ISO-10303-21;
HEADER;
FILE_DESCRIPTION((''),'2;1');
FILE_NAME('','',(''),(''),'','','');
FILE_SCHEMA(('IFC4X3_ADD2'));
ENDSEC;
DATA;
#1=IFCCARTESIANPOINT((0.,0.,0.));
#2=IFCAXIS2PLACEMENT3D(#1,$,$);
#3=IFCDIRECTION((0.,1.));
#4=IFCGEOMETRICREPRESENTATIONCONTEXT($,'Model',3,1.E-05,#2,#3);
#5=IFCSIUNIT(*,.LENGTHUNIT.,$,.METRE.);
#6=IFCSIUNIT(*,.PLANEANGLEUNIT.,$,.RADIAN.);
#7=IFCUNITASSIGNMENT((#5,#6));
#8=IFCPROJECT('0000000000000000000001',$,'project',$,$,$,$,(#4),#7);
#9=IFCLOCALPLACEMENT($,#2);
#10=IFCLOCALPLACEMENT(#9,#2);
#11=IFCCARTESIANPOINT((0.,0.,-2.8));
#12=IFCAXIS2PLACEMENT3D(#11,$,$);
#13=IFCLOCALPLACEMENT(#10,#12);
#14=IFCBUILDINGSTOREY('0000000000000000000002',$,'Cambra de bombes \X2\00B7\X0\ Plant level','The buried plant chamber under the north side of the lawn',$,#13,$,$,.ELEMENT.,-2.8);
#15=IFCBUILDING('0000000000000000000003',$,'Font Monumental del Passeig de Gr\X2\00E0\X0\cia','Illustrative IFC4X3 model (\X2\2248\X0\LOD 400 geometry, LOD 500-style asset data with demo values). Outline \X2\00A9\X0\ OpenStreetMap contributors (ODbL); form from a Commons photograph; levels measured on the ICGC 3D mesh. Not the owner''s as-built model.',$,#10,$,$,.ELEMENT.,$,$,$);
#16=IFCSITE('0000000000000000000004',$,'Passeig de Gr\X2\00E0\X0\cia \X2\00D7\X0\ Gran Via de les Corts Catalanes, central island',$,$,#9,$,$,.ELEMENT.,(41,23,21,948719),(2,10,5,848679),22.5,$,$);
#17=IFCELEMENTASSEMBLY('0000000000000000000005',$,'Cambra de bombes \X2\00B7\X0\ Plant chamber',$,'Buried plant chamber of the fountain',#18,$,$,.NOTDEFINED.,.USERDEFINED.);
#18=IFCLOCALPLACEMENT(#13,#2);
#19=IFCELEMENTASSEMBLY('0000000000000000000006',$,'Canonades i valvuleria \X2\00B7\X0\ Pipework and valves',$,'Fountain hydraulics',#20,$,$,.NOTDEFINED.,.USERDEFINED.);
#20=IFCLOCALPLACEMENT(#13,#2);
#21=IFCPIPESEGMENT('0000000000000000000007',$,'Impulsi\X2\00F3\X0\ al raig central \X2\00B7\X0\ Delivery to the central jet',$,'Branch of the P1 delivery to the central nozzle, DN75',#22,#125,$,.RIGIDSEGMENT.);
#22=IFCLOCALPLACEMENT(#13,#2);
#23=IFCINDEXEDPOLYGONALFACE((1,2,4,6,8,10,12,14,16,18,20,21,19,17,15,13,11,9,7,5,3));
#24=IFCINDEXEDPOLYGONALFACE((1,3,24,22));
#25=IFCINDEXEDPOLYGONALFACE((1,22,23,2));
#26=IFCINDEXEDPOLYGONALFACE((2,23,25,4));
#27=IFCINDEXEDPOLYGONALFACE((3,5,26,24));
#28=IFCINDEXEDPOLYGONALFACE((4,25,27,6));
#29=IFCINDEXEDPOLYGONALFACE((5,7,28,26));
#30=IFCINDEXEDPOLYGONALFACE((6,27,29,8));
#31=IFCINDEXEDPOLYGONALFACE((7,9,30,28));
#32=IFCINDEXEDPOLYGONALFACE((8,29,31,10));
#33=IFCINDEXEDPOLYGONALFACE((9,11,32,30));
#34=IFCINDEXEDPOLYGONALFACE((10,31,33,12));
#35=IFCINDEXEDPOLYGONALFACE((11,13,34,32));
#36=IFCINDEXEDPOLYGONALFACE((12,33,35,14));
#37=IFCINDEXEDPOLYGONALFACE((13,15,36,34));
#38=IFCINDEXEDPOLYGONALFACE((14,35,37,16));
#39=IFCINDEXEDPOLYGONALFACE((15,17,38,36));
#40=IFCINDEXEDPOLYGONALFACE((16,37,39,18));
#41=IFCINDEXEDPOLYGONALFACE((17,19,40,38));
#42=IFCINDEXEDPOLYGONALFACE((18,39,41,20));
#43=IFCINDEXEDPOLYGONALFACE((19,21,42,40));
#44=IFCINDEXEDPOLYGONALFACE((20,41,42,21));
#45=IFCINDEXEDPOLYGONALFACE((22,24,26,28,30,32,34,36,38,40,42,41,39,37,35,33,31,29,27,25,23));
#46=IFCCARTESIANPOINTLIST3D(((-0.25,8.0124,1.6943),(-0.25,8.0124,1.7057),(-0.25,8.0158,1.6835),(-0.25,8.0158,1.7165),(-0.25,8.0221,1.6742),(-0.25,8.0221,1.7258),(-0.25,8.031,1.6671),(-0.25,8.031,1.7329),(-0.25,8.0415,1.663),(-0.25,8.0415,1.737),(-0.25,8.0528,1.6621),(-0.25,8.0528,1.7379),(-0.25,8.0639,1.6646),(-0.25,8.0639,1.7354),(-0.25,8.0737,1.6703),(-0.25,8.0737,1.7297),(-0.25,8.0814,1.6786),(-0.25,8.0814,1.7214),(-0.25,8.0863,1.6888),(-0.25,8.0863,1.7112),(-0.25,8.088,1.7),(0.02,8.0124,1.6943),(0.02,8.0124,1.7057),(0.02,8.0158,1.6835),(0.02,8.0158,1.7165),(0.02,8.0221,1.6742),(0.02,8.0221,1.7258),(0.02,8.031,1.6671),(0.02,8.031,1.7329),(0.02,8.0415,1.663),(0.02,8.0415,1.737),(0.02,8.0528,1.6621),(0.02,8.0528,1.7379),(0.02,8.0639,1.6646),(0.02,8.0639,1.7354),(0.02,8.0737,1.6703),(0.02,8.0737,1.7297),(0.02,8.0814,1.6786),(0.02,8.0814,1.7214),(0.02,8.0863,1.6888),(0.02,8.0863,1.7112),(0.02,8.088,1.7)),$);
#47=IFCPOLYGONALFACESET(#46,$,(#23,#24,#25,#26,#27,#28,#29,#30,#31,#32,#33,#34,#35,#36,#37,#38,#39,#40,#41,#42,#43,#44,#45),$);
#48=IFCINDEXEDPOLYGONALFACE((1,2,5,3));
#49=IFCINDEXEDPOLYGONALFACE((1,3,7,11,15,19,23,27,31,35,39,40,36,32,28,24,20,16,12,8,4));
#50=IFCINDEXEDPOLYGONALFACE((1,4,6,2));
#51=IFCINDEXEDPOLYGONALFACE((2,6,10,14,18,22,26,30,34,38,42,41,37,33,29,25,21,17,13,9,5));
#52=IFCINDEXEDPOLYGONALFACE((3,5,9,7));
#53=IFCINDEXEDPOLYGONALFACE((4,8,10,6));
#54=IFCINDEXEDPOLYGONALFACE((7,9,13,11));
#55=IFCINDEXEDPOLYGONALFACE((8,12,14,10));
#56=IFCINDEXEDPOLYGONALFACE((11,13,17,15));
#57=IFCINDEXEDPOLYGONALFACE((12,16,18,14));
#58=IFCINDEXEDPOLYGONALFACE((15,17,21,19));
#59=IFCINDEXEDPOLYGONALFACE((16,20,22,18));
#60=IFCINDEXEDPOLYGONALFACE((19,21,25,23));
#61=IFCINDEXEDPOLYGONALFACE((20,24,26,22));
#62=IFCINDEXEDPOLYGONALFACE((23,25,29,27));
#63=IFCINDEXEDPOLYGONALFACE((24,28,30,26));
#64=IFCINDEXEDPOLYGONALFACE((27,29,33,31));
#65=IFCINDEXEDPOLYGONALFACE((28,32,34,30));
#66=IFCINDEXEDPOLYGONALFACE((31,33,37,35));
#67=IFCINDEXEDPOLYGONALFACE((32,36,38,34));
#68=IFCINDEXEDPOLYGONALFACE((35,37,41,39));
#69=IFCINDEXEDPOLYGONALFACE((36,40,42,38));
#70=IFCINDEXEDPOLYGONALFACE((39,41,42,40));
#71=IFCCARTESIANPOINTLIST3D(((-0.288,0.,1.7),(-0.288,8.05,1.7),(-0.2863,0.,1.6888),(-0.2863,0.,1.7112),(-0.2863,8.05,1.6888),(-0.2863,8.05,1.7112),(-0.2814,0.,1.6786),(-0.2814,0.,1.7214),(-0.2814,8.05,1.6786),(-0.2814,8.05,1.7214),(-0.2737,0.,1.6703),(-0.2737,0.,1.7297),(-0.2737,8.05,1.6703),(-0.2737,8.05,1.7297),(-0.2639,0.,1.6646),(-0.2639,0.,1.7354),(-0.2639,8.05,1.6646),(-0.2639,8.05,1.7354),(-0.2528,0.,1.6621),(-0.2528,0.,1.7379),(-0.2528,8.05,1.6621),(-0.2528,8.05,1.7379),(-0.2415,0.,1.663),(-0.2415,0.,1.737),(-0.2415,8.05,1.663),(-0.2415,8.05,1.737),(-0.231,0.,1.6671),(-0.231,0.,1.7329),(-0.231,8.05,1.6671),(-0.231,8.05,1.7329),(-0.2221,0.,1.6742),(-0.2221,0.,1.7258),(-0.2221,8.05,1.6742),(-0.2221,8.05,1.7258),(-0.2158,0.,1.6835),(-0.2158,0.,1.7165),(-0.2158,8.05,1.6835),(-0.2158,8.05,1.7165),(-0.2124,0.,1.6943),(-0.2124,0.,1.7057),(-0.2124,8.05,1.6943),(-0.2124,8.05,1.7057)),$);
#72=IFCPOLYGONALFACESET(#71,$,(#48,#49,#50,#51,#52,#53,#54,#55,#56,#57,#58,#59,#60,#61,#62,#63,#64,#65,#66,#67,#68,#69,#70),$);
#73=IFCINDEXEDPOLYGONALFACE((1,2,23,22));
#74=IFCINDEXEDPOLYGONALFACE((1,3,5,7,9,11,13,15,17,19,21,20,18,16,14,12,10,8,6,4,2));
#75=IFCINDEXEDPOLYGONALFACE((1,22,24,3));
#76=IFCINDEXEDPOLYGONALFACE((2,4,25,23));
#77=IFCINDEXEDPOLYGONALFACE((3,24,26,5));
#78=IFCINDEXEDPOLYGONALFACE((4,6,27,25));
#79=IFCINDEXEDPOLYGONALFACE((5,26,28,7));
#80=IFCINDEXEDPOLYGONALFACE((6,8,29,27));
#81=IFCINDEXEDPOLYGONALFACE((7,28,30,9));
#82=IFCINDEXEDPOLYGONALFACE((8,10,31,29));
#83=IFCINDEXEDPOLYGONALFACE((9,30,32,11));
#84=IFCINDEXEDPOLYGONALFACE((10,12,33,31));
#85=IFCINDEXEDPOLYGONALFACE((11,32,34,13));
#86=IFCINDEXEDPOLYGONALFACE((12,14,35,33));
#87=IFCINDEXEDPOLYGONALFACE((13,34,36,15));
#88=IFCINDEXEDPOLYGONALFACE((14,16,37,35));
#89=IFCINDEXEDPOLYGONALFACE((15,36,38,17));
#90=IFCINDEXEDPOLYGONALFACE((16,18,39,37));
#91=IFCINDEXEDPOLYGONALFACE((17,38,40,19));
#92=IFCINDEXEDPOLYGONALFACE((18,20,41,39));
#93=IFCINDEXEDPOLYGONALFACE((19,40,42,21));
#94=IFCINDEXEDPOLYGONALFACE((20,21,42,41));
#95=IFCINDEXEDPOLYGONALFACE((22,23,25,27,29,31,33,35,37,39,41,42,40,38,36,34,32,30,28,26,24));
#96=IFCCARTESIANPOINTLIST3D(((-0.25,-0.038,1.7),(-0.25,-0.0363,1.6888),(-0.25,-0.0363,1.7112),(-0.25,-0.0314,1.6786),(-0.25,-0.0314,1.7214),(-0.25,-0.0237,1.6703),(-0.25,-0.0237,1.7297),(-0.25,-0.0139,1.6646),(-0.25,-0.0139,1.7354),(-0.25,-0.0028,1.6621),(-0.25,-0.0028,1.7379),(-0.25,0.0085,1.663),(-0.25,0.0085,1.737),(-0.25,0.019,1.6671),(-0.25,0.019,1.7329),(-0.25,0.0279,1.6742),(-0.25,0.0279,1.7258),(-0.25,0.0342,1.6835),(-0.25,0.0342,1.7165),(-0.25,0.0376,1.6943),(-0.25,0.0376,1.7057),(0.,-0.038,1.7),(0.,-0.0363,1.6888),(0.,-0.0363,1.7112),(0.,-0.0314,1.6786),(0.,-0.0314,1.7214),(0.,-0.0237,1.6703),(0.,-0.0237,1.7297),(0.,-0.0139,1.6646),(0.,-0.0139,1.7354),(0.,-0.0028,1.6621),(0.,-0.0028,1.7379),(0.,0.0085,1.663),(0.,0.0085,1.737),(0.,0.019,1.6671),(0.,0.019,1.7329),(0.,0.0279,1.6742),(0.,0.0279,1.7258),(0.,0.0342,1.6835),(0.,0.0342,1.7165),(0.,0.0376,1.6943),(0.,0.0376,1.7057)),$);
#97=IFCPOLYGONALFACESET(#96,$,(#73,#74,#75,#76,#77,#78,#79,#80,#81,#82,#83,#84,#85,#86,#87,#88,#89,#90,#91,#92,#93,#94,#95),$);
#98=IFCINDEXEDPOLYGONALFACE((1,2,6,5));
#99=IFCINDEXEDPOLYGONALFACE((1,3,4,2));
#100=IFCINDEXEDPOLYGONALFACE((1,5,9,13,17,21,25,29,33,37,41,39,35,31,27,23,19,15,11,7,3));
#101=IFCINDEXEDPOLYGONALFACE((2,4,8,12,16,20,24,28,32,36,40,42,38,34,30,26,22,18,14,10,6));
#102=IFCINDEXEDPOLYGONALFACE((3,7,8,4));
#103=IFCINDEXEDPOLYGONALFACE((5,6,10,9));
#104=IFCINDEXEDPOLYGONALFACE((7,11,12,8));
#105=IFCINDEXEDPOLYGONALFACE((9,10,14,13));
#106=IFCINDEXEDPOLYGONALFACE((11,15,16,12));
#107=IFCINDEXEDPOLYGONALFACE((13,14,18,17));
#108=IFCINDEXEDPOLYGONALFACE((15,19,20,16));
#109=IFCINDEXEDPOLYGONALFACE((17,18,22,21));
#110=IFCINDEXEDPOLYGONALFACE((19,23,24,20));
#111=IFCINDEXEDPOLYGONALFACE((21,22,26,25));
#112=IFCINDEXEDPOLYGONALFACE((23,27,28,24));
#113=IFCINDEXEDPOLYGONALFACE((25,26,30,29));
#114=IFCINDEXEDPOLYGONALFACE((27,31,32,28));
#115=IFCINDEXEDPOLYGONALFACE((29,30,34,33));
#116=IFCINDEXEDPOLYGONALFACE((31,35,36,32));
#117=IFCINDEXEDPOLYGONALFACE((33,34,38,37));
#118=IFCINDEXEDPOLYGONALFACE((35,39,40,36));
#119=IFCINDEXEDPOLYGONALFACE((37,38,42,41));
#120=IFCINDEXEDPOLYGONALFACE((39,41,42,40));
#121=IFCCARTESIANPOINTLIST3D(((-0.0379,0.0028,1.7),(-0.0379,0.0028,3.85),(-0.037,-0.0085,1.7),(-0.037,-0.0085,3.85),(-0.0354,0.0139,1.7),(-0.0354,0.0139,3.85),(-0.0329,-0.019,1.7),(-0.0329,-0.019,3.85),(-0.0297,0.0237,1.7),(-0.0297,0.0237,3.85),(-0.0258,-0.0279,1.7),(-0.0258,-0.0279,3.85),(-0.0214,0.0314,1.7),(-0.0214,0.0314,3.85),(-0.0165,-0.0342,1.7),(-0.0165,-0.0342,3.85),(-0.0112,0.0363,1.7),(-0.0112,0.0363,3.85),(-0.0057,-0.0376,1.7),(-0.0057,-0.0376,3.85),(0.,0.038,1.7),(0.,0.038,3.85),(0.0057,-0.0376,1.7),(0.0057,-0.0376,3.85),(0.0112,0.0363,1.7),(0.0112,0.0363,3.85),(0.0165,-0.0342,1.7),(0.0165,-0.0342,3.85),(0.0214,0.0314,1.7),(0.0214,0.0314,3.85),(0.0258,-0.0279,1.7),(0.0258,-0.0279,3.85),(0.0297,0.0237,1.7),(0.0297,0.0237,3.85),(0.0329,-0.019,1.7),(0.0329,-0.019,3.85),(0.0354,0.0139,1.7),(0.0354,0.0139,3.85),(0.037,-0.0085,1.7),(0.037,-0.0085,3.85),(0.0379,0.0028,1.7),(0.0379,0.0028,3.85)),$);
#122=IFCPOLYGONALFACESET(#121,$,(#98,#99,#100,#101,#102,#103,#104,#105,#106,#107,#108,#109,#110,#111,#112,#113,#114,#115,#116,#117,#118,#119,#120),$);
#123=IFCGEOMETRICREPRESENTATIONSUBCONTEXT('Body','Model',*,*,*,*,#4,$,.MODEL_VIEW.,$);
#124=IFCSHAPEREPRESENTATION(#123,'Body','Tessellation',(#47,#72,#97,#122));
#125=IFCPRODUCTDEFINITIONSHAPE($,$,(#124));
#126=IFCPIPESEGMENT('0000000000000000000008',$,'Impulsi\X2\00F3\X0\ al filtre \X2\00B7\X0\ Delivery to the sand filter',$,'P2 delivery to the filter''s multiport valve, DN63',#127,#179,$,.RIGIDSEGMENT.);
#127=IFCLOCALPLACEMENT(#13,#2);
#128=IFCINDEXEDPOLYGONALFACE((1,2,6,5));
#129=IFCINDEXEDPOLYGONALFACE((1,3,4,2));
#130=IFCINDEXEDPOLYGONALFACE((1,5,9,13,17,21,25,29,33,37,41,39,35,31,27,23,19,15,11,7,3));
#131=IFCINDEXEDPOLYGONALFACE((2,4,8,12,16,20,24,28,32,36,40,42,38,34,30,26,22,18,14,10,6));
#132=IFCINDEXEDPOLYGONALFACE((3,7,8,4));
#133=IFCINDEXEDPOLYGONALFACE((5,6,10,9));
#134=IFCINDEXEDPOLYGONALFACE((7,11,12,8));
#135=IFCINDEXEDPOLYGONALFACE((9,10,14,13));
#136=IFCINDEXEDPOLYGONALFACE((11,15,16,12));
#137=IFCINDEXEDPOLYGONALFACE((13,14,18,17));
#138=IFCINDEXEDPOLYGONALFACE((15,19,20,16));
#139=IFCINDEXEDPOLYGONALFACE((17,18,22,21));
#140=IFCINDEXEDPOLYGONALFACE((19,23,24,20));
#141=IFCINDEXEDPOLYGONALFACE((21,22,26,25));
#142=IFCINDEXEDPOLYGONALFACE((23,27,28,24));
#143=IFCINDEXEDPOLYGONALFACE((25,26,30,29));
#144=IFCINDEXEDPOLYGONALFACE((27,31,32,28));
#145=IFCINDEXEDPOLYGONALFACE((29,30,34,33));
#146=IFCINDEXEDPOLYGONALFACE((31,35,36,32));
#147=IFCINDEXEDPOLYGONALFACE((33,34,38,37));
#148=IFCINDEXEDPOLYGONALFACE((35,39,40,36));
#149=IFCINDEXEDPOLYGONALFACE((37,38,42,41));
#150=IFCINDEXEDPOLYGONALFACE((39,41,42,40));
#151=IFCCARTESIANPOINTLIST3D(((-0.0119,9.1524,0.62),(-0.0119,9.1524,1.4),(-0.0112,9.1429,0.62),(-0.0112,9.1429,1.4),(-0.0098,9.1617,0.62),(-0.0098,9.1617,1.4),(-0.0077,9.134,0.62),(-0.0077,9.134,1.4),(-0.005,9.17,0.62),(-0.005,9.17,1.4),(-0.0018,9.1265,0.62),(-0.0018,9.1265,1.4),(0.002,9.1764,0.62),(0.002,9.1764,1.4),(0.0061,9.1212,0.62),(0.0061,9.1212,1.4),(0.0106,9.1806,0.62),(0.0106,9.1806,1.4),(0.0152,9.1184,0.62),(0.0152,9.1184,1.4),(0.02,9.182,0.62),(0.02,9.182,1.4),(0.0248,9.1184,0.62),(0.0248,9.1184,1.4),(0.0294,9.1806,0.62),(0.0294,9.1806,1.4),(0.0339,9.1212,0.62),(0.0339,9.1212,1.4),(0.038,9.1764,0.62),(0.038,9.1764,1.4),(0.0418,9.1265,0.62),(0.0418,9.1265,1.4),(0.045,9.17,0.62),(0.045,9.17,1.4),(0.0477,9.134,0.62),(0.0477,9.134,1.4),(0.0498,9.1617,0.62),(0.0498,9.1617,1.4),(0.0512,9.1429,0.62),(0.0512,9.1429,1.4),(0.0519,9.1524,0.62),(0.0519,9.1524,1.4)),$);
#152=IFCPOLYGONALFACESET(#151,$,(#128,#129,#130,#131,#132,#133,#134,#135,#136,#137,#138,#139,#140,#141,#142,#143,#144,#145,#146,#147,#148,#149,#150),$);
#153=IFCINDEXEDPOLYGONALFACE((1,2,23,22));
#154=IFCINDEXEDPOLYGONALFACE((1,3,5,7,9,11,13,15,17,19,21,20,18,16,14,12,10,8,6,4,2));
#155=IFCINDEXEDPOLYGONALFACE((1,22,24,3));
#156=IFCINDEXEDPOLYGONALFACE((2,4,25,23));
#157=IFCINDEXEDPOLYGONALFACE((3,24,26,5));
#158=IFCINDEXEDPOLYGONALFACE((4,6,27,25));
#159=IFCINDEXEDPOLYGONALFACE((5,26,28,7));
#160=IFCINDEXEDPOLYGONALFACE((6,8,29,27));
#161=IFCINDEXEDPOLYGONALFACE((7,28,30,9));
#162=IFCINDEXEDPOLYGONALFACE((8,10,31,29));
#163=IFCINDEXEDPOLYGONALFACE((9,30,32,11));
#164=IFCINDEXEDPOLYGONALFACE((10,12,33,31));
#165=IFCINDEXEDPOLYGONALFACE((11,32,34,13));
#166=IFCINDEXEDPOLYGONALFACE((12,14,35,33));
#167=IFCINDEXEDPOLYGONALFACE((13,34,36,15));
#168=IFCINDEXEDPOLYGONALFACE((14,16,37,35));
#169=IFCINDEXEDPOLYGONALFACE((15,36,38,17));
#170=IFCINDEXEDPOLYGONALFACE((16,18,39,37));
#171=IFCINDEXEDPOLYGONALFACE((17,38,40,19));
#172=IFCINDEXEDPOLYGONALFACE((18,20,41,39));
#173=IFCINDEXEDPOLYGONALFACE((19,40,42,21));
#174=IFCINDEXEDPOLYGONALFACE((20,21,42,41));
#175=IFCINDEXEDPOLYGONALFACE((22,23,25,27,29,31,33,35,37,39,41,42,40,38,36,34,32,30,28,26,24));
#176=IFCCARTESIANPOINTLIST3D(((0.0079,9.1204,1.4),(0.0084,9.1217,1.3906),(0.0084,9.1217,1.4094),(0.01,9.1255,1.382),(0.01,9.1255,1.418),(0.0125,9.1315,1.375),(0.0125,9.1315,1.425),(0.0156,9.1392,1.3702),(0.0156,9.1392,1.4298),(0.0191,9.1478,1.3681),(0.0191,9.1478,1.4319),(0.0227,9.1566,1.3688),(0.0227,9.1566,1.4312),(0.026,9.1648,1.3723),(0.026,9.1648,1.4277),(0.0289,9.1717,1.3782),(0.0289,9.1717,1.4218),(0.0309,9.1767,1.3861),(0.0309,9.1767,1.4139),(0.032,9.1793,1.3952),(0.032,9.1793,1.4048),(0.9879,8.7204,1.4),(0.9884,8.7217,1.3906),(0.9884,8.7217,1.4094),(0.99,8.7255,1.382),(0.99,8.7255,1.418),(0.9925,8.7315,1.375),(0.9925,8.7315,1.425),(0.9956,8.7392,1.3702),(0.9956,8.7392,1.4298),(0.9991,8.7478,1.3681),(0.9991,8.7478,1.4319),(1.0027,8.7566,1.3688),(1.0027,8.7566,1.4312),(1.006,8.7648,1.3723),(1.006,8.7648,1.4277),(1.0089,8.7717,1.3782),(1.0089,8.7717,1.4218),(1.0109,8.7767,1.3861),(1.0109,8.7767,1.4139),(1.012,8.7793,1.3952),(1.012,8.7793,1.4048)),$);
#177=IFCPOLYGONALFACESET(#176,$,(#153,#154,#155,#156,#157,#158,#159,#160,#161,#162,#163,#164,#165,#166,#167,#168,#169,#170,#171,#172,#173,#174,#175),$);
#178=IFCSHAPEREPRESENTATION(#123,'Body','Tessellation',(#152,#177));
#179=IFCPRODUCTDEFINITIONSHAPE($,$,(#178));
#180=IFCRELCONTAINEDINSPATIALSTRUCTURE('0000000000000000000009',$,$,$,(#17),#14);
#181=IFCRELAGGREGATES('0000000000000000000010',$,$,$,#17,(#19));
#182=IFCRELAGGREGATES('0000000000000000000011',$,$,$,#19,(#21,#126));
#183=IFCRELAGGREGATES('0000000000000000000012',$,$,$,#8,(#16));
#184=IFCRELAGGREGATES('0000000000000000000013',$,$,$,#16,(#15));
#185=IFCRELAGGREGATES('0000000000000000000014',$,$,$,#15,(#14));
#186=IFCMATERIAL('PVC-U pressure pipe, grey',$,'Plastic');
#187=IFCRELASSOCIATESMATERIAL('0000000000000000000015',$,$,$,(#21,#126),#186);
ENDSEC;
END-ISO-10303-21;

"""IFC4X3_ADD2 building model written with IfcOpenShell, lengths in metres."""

from ifc_helpers import new_model, si_unit, direction, frame, origin, origin_2d_with_axis, place, context, subcontext, project, spatial, circle, extrude, material, element, aggregate, save


model = new_model("IFC4X3_ADD2")

# Units and contexts
model_context = context("Model", 3, precision=1e-05, world=origin(), true_north=direction((0.0, 1.0)))
body_context = subcontext(model_context, "Body", "Model", "MODEL_VIEW")
ifc_project = project(units=[si_unit("LENGTHUNIT", "METRE"), si_unit("PLANEANGLEUNIT", "RADIAN")], contexts=[model_context])

# Site, building, storey
site_placement = place(None, origin())
site = spatial("IfcSite", under=ifc_project, at=site_placement, Name="Passeig de Gràcia × Gran Via de les Corts Catalanes, central island", CompositionType="ELEMENT", RefLatitude=(41, 23, 21, 948719), RefLongitude=(2, 10, 5, 848679), RefElevation=22.5)
building_placement = place(site_placement, origin())
building = spatial("IfcBuilding", under=site, at=building_placement, Name="Font Monumental del Passeig de Gràcia", Description="Illustrative IFC4X3 model (≈LOD 400 geometry, LOD 500-style asset data with demo values). Outline © OpenStreetMap contributors (ODbL); form from a Commons photograph; levels measured on the ICGC 3D mesh. Not the owner's as-built model.", CompositionType="ELEMENT")
storey_placement = place(building_placement, frame((0.0, 0.0, -2.8)))
storey = spatial("IfcBuildingStorey", under=building, at=storey_placement, Name="Cambra de bombes · Plant level", Description="The buried plant chamber under the north side of the lawn", CompositionType="ELEMENT", Elevation=-2.8)

# Element assemblies, pipe segments
assembly_1_placement = place(building_placement, origin())
assembly_1 = element("IfcElementAssembly", 1, at=assembly_1_placement, inside=storey, Name="Cambra de bombes · Plant chamber", ObjectType="Buried plant chamber of the fountain", AssemblyPlace="NOTDEFINED", PredefinedType="USERDEFINED")
assembly_2_placement = place(building_placement, origin())
assembly_2 = element("IfcElementAssembly", 2, at=assembly_2_placement, Name="Canonades i valvuleria · Pipework and valves", ObjectType="Fountain hydraulics", AssemblyPlace="NOTDEFINED", PredefinedType="USERDEFINED")
aggregate(assembly_1, [assembly_2])
ifc_material_1 = material(Name="PVC-U pressure pipe, grey", Category="Plastic")
pipe_segment_1_placement = place(building_placement, origin())
pipe_segment_1 = element("IfcPipeSegment", 3, at=pipe_segment_1_placement, material=ifc_material_1, Name="Impulsió al raig central · Delivery to the central jet", ObjectType="Branch of the P1 delivery to the central nozzle, DN75", PredefinedType="RIGIDSEGMENT", context=body_context, shape_type="SweptSolid", body=[
    extrude(circle(Radius=0.038, at=origin_2d_with_axis()), frame((0.02, 8.05, -1.1), z_axis=(-1.0, 0.0, 0.0), x_axis=(0.0, 1.0, 0.0)), (0.0, 0.0, 1.0), 0.27),
    extrude(circle(Radius=0.038, at=origin_2d_with_axis()), frame((-0.25, 8.05, -1.1), z_axis=(0.0, -1.0, 0.0), x_axis=(-1.0, 0.0, 0.0)), (0.0, 0.0, 1.0), 8.05),
    extrude(circle(Radius=0.038, at=origin_2d_with_axis()), frame((-0.25, 0.0, -1.1), z_axis=(1.0, 0.0, 0.0), x_axis=(0.0, -1.0, 0.0)), (0.0, 0.0, 1.0), 0.25),
    extrude(circle(Radius=0.038, at=origin_2d_with_axis()), frame((0.0, 0.0, -1.1), z_axis=(0.0, 0.0, 1.0), x_axis=(0.0, 1.0, 0.0)), (0.0, 0.0, 1.0), 2.15),
])
pipe_segment_2_placement = place(building_placement, origin())
pipe_segment_2 = element("IfcPipeSegment", 4, at=pipe_segment_2_placement, material=ifc_material_1, Name="Impulsió al filtre · Delivery to the sand filter", ObjectType="P2 delivery to the filter's multiport valve, DN63", PredefinedType="RIGIDSEGMENT", context=body_context, shape_type="SweptSolid", body=[
    extrude(circle(Radius=0.032, at=origin_2d_with_axis()), frame((0.02, 9.15, -2.18), z_axis=(0.0, 0.0, 1.0), x_axis=(0.0, 1.0, 0.0)), (0.0, 0.0, 1.0), 0.78),
    extrude(circle(Radius=0.032, at=origin_2d_with_axis()), frame((0.02, 9.15, -1.4), z_axis=(0.925848, -0.377897, 0.0), x_axis=(-0.377897, -0.925848, 0.0)), (0.0, 0.0, 1.0), 1.0585),
])
aggregate(assembly_2, [pipe_segment_1, pipe_segment_2])

save(model, "model.ifc")
